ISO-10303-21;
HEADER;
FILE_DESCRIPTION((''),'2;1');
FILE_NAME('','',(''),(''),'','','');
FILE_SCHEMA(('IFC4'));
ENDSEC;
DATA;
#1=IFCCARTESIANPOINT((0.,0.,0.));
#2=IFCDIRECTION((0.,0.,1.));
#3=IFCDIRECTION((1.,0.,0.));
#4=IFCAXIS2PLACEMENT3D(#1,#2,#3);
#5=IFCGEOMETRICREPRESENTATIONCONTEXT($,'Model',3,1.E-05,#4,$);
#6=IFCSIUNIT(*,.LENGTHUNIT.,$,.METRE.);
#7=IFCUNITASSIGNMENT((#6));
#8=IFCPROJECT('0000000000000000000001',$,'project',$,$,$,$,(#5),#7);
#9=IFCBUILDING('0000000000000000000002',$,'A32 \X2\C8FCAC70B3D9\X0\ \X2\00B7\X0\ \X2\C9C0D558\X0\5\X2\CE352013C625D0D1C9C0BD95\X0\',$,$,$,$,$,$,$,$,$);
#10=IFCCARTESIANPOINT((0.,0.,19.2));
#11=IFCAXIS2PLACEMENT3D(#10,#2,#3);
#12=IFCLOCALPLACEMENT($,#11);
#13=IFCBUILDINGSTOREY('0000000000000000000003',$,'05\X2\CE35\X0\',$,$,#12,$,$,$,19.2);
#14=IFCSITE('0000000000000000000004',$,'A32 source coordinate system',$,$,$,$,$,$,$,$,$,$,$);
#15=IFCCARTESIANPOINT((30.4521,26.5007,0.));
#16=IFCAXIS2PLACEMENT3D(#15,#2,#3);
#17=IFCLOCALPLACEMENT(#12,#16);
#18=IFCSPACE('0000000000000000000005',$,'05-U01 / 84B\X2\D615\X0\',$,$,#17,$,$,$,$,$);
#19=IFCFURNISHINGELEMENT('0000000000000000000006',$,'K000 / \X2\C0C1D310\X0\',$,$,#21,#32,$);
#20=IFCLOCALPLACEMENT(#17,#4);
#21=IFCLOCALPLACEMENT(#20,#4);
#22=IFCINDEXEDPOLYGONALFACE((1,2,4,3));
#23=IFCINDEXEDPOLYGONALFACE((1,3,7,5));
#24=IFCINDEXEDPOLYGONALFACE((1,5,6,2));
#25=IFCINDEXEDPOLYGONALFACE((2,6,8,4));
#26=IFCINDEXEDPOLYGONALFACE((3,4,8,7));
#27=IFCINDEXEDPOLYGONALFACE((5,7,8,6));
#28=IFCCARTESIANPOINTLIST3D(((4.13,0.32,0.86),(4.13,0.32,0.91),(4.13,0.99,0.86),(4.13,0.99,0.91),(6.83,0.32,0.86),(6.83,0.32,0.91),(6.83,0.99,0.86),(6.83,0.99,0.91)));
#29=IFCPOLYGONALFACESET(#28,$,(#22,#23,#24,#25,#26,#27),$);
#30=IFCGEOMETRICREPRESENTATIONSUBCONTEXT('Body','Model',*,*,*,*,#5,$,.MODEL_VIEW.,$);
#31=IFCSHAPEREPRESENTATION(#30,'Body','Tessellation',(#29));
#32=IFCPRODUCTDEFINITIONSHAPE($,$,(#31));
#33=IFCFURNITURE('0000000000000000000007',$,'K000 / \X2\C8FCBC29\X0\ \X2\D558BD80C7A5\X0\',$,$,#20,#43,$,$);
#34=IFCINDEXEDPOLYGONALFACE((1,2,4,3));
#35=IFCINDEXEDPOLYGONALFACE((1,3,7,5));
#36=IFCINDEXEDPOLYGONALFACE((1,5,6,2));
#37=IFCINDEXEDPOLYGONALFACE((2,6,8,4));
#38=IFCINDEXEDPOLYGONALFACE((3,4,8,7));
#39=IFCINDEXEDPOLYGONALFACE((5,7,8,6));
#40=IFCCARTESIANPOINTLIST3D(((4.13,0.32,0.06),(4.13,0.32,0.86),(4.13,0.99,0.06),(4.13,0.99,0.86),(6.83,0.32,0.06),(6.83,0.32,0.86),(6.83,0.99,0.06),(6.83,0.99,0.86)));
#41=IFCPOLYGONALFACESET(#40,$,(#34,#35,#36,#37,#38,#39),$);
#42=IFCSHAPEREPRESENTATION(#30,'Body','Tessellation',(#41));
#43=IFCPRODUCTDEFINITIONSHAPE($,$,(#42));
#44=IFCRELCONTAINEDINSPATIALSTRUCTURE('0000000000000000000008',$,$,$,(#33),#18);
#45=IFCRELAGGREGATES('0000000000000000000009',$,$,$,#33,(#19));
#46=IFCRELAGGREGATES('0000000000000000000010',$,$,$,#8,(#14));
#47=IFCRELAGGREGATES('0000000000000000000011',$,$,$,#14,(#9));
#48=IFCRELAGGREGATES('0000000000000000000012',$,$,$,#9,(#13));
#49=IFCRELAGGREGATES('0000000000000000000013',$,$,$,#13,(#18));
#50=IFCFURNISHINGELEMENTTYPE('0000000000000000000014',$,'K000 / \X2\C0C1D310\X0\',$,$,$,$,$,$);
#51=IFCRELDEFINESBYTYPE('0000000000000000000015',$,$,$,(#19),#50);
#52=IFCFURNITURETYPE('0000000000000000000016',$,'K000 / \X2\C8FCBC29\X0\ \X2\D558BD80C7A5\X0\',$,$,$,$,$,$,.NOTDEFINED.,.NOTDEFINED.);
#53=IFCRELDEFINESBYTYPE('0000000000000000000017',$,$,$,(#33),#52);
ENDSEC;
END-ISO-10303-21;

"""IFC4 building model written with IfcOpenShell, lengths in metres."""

from ifc_helpers import new_model, si_unit, frame, origin, origin_with_axes, place, context, subcontext, project, spatial, polyline, outline, extrude, source, transform, mapped, type_object, type_shapes, element, aggregate, save


model = new_model("IFC4")

# Units and contexts
model_context = context("Model", 3, precision=1e-05, world=origin_with_axes())
body_context = subcontext(model_context, "Body", "Model", "MODEL_VIEW")
ifc_project = project(units=[si_unit("LENGTHUNIT", "METRE")], contexts=[model_context])

# Site, building, storey, space
site = spatial("IfcSite", under=ifc_project, Name="A32 source coordinate system")
building = spatial("IfcBuilding", under=site, Name="A32 주거동 · 지하5층–옥탑지붕")
storey_placement = place(None, frame((0.0, 0.0, 19.2), z_axis=(0.0, 0.0, 1.0), x_axis=(1.0, 0.0, 0.0)))
storey = spatial("IfcBuildingStorey", under=building, at=storey_placement, Name="05층", Elevation=19.2)
space_placement = place(storey_placement, frame((30.4521, 26.5007, 0.0), z_axis=(0.0, 0.0, 1.0), x_axis=(1.0, 0.0, 0.0)))
space = spatial("IfcSpace", under=storey, at=space_placement, Name="05-U01 / 84B형")

# Furnishing element
furnishing_element_type = type_object("IfcFurnishingElementType", Name="K000 / 상판")
shared_shape_1 = source(origin(), body_context, "Body", "SweptSolid", [
    extrude(outline(polyline([(4.13, 0.32), (4.13, 0.99), (6.83, 0.99), (6.83, 0.32), (4.13, 0.32)])), frame((0.0, 0.0, 0.86)), (0.0, 0.0, 1.0), 0.05),
])
type_shapes(furnishing_element_type, [shared_shape_1])
furniture_placement = place(space_placement, origin_with_axes())
furnishing_placement = place(furniture_placement, origin_with_axes())
furnishing = element("IfcFurnishingElement", 1, at=furnishing_placement, type_object=furnishing_element_type, Name="K000 / 상판", context=body_context, shape_type="MappedRepresentation", body=[
    mapped(shared_shape_1, transform((0.0, 0.0, 0.0), scale=1.0)),
])

# Furniture
furniture_type = type_object("IfcFurnitureType", Name="K000 / 주방 하부장", AssemblyPlace="NOTDEFINED", PredefinedType="NOTDEFINED")
shared_shape_2 = source(origin(), body_context, "Body", "SweptSolid", [
    extrude(outline(polyline([(6.83, 0.32), (4.13, 0.32), (4.13, 0.99), (6.83, 0.99), (6.83, 0.32)])), frame((0.0, 0.0, 0.06)), (0.0, 0.0, 1.0), 0.8),
])
type_shapes(furniture_type, [shared_shape_2])
furniture = element("IfcFurniture", 2, at=furniture_placement, inside=space, type_object=furniture_type, Name="K000 / 주방 하부장", context=body_context, shape_type="MappedRepresentation", body=[
    mapped(shared_shape_2, transform((0.0, 0.0, 0.0), scale=1.0)),
])
aggregate(furniture, [furnishing])

save(model, "model.ifc")
